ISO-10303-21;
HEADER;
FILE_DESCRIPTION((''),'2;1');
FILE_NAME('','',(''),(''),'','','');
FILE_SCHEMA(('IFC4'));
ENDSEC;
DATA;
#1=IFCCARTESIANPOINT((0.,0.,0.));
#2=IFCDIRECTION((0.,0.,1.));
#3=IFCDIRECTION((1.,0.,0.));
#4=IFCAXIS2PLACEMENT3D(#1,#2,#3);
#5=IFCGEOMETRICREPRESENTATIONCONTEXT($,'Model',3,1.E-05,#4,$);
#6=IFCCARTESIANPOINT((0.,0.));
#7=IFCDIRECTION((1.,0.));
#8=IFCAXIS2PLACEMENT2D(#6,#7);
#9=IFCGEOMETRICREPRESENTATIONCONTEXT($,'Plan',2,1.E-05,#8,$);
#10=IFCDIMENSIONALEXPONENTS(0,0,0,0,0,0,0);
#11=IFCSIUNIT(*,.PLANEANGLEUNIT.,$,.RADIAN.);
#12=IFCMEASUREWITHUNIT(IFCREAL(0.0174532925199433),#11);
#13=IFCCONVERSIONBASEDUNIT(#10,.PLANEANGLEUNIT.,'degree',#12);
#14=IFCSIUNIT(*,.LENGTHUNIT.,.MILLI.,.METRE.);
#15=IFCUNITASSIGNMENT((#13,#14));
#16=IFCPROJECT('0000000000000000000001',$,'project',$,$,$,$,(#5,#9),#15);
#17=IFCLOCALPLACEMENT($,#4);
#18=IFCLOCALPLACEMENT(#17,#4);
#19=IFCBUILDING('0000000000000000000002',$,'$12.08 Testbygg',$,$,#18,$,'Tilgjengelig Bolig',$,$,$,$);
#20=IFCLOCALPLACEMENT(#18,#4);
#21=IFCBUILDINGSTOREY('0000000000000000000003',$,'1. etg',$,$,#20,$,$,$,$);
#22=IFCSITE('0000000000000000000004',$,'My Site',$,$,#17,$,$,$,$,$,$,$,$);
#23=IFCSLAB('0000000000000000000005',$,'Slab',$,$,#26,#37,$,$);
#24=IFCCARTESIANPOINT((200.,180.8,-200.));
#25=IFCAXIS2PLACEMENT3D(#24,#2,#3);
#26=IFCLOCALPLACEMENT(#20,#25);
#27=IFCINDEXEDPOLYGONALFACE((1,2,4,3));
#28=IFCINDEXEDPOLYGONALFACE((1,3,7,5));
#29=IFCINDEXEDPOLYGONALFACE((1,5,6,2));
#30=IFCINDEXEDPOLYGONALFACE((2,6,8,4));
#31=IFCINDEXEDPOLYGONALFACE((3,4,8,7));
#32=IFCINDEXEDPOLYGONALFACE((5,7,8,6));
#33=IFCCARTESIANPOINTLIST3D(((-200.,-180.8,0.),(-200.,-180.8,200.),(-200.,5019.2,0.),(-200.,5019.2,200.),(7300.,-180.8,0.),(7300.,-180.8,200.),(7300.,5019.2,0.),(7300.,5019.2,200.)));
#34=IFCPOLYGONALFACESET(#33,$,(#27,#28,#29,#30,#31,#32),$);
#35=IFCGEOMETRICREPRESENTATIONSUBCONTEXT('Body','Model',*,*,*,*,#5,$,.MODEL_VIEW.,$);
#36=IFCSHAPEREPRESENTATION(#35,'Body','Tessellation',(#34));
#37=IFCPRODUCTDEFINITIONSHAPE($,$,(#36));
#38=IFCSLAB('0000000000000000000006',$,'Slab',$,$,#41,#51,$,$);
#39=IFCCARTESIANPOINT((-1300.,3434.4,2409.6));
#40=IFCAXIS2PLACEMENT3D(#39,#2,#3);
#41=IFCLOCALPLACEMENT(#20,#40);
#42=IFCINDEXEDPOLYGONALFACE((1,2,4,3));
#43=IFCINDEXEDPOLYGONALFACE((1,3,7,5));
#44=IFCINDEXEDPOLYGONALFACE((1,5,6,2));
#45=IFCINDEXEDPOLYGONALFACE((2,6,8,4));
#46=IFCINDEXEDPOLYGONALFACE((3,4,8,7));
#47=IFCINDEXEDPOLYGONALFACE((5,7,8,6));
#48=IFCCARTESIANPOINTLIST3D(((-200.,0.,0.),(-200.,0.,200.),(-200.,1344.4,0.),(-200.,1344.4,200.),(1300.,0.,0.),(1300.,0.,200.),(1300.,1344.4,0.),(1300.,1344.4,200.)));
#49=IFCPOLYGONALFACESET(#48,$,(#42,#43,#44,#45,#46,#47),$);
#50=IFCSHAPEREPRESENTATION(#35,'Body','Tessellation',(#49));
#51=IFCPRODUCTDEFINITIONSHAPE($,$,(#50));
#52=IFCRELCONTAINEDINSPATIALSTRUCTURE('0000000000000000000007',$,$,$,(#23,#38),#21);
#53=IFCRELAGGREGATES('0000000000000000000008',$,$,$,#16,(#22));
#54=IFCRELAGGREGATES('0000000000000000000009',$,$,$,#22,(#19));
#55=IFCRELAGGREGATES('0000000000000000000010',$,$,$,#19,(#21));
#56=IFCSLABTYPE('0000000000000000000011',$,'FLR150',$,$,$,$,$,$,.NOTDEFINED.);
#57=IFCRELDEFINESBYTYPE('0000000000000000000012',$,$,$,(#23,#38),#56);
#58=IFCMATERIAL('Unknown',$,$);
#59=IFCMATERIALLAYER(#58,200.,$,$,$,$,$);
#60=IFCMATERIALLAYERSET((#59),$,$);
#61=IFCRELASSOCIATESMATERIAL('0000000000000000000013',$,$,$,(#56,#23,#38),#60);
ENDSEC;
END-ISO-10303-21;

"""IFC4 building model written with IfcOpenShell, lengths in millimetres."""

from ifc_helpers import new_model, entity, si_unit, converted_unit, frame, origin_with_axes, origin_2d_with_axis, place, context, subcontext, project, spatial, line, indexed_curve, outline, extrude, material, layer, layer_set, layer_usage, type_object, element, save


model = new_model("IFC4")

# Units and contexts
model_context = context("Model", 3, precision=1e-05, world=origin_with_axes())
plan_context = context("Plan", 2, precision=1e-05, world=origin_2d_with_axis())
body_context = subcontext(model_context, "Body", "Model", "MODEL_VIEW")
ifc_project = project(units=[converted_unit("PLANEANGLEUNIT", "degree", entity("IfcReal", 0.0174532925199433), si_unit("PLANEANGLEUNIT", "RADIAN"), dimensions=[0, 0, 0, 0, 0, 0, 0]), si_unit("LENGTHUNIT", "METRE", prefix="MILLI")], contexts=[model_context, plan_context])

# Site, building, storey
site_placement = place(None, origin_with_axes())
site = spatial("IfcSite", under=ifc_project, at=site_placement, Name="My Site")
building_placement = place(site_placement, origin_with_axes())
building = spatial("IfcBuilding", under=site, at=building_placement, Name="$12.08 Testbygg", LongName="Tilgjengelig Bolig")
storey_placement = place(building_placement, origin_with_axes())
storey = spatial("IfcBuildingStorey", under=building, at=storey_placement, Name="1. etg")

# Shared definitions
ifc_material = material(Name="Unknown")

# Slabs
ifc_layer_1 = layer(ifc_material, 200.0)
ifc_layer_set_1 = layer_set([ifc_layer_1])
ifc_layer_usage_1 = layer_usage(ifc_layer_set_1, "AXIS3", "POSITIVE", 0.0)
slab_type = type_object("IfcSlabType", Name="FLR150", PredefinedType="NOTDEFINED", material=ifc_layer_set_1)
slab_1_placement = place(storey_placement, frame((200.0, 180.8, -200.0), z_axis=(0.0, 0.0, 1.0), x_axis=(1.0, 0.0, 0.0)))
element("IfcSlab", 1, at=slab_1_placement, inside=storey, type_object=slab_type, material=ifc_layer_usage_1, Name="Slab", context=body_context, shape_type="SweptSolid", body=[
    extrude(outline(indexed_curve([(7300.0, 5019.2), (7300.0, -180.8), (-200.0, -180.8), (-200.0, 5019.2)], segments=[line(3, 2), line(2, 1), line(1, 4), line(4, 3)], self_intersect=False)), None, (0.0, 0.0, 1.0), 200.0),
])
ifc_layer_usage_2 = layer_usage(ifc_layer_set_1, "AXIS3", "POSITIVE", 0.0)
slab_2_placement = place(storey_placement, frame((-1300.0, 3434.4, 2409.6), z_axis=(0.0, 0.0, 1.0), x_axis=(1.0, 0.0, 0.0)))
element("IfcSlab", 2, at=slab_2_placement, inside=storey, type_object=slab_type, material=ifc_layer_usage_2, Name="Slab", context=body_context, shape_type="SweptSolid", body=[
    extrude(outline(indexed_curve([(-200.0, 1344.4), (1300.0, 1344.4), (1300.0, 0.0), (-200.0, 0.0)], segments=[line(4, 1), line(1, 2), line(2, 3), line(3, 4)], self_intersect=False)), None, (0.0, 0.0, 1.0), 200.0),
])

save(model, "model.ifc")
